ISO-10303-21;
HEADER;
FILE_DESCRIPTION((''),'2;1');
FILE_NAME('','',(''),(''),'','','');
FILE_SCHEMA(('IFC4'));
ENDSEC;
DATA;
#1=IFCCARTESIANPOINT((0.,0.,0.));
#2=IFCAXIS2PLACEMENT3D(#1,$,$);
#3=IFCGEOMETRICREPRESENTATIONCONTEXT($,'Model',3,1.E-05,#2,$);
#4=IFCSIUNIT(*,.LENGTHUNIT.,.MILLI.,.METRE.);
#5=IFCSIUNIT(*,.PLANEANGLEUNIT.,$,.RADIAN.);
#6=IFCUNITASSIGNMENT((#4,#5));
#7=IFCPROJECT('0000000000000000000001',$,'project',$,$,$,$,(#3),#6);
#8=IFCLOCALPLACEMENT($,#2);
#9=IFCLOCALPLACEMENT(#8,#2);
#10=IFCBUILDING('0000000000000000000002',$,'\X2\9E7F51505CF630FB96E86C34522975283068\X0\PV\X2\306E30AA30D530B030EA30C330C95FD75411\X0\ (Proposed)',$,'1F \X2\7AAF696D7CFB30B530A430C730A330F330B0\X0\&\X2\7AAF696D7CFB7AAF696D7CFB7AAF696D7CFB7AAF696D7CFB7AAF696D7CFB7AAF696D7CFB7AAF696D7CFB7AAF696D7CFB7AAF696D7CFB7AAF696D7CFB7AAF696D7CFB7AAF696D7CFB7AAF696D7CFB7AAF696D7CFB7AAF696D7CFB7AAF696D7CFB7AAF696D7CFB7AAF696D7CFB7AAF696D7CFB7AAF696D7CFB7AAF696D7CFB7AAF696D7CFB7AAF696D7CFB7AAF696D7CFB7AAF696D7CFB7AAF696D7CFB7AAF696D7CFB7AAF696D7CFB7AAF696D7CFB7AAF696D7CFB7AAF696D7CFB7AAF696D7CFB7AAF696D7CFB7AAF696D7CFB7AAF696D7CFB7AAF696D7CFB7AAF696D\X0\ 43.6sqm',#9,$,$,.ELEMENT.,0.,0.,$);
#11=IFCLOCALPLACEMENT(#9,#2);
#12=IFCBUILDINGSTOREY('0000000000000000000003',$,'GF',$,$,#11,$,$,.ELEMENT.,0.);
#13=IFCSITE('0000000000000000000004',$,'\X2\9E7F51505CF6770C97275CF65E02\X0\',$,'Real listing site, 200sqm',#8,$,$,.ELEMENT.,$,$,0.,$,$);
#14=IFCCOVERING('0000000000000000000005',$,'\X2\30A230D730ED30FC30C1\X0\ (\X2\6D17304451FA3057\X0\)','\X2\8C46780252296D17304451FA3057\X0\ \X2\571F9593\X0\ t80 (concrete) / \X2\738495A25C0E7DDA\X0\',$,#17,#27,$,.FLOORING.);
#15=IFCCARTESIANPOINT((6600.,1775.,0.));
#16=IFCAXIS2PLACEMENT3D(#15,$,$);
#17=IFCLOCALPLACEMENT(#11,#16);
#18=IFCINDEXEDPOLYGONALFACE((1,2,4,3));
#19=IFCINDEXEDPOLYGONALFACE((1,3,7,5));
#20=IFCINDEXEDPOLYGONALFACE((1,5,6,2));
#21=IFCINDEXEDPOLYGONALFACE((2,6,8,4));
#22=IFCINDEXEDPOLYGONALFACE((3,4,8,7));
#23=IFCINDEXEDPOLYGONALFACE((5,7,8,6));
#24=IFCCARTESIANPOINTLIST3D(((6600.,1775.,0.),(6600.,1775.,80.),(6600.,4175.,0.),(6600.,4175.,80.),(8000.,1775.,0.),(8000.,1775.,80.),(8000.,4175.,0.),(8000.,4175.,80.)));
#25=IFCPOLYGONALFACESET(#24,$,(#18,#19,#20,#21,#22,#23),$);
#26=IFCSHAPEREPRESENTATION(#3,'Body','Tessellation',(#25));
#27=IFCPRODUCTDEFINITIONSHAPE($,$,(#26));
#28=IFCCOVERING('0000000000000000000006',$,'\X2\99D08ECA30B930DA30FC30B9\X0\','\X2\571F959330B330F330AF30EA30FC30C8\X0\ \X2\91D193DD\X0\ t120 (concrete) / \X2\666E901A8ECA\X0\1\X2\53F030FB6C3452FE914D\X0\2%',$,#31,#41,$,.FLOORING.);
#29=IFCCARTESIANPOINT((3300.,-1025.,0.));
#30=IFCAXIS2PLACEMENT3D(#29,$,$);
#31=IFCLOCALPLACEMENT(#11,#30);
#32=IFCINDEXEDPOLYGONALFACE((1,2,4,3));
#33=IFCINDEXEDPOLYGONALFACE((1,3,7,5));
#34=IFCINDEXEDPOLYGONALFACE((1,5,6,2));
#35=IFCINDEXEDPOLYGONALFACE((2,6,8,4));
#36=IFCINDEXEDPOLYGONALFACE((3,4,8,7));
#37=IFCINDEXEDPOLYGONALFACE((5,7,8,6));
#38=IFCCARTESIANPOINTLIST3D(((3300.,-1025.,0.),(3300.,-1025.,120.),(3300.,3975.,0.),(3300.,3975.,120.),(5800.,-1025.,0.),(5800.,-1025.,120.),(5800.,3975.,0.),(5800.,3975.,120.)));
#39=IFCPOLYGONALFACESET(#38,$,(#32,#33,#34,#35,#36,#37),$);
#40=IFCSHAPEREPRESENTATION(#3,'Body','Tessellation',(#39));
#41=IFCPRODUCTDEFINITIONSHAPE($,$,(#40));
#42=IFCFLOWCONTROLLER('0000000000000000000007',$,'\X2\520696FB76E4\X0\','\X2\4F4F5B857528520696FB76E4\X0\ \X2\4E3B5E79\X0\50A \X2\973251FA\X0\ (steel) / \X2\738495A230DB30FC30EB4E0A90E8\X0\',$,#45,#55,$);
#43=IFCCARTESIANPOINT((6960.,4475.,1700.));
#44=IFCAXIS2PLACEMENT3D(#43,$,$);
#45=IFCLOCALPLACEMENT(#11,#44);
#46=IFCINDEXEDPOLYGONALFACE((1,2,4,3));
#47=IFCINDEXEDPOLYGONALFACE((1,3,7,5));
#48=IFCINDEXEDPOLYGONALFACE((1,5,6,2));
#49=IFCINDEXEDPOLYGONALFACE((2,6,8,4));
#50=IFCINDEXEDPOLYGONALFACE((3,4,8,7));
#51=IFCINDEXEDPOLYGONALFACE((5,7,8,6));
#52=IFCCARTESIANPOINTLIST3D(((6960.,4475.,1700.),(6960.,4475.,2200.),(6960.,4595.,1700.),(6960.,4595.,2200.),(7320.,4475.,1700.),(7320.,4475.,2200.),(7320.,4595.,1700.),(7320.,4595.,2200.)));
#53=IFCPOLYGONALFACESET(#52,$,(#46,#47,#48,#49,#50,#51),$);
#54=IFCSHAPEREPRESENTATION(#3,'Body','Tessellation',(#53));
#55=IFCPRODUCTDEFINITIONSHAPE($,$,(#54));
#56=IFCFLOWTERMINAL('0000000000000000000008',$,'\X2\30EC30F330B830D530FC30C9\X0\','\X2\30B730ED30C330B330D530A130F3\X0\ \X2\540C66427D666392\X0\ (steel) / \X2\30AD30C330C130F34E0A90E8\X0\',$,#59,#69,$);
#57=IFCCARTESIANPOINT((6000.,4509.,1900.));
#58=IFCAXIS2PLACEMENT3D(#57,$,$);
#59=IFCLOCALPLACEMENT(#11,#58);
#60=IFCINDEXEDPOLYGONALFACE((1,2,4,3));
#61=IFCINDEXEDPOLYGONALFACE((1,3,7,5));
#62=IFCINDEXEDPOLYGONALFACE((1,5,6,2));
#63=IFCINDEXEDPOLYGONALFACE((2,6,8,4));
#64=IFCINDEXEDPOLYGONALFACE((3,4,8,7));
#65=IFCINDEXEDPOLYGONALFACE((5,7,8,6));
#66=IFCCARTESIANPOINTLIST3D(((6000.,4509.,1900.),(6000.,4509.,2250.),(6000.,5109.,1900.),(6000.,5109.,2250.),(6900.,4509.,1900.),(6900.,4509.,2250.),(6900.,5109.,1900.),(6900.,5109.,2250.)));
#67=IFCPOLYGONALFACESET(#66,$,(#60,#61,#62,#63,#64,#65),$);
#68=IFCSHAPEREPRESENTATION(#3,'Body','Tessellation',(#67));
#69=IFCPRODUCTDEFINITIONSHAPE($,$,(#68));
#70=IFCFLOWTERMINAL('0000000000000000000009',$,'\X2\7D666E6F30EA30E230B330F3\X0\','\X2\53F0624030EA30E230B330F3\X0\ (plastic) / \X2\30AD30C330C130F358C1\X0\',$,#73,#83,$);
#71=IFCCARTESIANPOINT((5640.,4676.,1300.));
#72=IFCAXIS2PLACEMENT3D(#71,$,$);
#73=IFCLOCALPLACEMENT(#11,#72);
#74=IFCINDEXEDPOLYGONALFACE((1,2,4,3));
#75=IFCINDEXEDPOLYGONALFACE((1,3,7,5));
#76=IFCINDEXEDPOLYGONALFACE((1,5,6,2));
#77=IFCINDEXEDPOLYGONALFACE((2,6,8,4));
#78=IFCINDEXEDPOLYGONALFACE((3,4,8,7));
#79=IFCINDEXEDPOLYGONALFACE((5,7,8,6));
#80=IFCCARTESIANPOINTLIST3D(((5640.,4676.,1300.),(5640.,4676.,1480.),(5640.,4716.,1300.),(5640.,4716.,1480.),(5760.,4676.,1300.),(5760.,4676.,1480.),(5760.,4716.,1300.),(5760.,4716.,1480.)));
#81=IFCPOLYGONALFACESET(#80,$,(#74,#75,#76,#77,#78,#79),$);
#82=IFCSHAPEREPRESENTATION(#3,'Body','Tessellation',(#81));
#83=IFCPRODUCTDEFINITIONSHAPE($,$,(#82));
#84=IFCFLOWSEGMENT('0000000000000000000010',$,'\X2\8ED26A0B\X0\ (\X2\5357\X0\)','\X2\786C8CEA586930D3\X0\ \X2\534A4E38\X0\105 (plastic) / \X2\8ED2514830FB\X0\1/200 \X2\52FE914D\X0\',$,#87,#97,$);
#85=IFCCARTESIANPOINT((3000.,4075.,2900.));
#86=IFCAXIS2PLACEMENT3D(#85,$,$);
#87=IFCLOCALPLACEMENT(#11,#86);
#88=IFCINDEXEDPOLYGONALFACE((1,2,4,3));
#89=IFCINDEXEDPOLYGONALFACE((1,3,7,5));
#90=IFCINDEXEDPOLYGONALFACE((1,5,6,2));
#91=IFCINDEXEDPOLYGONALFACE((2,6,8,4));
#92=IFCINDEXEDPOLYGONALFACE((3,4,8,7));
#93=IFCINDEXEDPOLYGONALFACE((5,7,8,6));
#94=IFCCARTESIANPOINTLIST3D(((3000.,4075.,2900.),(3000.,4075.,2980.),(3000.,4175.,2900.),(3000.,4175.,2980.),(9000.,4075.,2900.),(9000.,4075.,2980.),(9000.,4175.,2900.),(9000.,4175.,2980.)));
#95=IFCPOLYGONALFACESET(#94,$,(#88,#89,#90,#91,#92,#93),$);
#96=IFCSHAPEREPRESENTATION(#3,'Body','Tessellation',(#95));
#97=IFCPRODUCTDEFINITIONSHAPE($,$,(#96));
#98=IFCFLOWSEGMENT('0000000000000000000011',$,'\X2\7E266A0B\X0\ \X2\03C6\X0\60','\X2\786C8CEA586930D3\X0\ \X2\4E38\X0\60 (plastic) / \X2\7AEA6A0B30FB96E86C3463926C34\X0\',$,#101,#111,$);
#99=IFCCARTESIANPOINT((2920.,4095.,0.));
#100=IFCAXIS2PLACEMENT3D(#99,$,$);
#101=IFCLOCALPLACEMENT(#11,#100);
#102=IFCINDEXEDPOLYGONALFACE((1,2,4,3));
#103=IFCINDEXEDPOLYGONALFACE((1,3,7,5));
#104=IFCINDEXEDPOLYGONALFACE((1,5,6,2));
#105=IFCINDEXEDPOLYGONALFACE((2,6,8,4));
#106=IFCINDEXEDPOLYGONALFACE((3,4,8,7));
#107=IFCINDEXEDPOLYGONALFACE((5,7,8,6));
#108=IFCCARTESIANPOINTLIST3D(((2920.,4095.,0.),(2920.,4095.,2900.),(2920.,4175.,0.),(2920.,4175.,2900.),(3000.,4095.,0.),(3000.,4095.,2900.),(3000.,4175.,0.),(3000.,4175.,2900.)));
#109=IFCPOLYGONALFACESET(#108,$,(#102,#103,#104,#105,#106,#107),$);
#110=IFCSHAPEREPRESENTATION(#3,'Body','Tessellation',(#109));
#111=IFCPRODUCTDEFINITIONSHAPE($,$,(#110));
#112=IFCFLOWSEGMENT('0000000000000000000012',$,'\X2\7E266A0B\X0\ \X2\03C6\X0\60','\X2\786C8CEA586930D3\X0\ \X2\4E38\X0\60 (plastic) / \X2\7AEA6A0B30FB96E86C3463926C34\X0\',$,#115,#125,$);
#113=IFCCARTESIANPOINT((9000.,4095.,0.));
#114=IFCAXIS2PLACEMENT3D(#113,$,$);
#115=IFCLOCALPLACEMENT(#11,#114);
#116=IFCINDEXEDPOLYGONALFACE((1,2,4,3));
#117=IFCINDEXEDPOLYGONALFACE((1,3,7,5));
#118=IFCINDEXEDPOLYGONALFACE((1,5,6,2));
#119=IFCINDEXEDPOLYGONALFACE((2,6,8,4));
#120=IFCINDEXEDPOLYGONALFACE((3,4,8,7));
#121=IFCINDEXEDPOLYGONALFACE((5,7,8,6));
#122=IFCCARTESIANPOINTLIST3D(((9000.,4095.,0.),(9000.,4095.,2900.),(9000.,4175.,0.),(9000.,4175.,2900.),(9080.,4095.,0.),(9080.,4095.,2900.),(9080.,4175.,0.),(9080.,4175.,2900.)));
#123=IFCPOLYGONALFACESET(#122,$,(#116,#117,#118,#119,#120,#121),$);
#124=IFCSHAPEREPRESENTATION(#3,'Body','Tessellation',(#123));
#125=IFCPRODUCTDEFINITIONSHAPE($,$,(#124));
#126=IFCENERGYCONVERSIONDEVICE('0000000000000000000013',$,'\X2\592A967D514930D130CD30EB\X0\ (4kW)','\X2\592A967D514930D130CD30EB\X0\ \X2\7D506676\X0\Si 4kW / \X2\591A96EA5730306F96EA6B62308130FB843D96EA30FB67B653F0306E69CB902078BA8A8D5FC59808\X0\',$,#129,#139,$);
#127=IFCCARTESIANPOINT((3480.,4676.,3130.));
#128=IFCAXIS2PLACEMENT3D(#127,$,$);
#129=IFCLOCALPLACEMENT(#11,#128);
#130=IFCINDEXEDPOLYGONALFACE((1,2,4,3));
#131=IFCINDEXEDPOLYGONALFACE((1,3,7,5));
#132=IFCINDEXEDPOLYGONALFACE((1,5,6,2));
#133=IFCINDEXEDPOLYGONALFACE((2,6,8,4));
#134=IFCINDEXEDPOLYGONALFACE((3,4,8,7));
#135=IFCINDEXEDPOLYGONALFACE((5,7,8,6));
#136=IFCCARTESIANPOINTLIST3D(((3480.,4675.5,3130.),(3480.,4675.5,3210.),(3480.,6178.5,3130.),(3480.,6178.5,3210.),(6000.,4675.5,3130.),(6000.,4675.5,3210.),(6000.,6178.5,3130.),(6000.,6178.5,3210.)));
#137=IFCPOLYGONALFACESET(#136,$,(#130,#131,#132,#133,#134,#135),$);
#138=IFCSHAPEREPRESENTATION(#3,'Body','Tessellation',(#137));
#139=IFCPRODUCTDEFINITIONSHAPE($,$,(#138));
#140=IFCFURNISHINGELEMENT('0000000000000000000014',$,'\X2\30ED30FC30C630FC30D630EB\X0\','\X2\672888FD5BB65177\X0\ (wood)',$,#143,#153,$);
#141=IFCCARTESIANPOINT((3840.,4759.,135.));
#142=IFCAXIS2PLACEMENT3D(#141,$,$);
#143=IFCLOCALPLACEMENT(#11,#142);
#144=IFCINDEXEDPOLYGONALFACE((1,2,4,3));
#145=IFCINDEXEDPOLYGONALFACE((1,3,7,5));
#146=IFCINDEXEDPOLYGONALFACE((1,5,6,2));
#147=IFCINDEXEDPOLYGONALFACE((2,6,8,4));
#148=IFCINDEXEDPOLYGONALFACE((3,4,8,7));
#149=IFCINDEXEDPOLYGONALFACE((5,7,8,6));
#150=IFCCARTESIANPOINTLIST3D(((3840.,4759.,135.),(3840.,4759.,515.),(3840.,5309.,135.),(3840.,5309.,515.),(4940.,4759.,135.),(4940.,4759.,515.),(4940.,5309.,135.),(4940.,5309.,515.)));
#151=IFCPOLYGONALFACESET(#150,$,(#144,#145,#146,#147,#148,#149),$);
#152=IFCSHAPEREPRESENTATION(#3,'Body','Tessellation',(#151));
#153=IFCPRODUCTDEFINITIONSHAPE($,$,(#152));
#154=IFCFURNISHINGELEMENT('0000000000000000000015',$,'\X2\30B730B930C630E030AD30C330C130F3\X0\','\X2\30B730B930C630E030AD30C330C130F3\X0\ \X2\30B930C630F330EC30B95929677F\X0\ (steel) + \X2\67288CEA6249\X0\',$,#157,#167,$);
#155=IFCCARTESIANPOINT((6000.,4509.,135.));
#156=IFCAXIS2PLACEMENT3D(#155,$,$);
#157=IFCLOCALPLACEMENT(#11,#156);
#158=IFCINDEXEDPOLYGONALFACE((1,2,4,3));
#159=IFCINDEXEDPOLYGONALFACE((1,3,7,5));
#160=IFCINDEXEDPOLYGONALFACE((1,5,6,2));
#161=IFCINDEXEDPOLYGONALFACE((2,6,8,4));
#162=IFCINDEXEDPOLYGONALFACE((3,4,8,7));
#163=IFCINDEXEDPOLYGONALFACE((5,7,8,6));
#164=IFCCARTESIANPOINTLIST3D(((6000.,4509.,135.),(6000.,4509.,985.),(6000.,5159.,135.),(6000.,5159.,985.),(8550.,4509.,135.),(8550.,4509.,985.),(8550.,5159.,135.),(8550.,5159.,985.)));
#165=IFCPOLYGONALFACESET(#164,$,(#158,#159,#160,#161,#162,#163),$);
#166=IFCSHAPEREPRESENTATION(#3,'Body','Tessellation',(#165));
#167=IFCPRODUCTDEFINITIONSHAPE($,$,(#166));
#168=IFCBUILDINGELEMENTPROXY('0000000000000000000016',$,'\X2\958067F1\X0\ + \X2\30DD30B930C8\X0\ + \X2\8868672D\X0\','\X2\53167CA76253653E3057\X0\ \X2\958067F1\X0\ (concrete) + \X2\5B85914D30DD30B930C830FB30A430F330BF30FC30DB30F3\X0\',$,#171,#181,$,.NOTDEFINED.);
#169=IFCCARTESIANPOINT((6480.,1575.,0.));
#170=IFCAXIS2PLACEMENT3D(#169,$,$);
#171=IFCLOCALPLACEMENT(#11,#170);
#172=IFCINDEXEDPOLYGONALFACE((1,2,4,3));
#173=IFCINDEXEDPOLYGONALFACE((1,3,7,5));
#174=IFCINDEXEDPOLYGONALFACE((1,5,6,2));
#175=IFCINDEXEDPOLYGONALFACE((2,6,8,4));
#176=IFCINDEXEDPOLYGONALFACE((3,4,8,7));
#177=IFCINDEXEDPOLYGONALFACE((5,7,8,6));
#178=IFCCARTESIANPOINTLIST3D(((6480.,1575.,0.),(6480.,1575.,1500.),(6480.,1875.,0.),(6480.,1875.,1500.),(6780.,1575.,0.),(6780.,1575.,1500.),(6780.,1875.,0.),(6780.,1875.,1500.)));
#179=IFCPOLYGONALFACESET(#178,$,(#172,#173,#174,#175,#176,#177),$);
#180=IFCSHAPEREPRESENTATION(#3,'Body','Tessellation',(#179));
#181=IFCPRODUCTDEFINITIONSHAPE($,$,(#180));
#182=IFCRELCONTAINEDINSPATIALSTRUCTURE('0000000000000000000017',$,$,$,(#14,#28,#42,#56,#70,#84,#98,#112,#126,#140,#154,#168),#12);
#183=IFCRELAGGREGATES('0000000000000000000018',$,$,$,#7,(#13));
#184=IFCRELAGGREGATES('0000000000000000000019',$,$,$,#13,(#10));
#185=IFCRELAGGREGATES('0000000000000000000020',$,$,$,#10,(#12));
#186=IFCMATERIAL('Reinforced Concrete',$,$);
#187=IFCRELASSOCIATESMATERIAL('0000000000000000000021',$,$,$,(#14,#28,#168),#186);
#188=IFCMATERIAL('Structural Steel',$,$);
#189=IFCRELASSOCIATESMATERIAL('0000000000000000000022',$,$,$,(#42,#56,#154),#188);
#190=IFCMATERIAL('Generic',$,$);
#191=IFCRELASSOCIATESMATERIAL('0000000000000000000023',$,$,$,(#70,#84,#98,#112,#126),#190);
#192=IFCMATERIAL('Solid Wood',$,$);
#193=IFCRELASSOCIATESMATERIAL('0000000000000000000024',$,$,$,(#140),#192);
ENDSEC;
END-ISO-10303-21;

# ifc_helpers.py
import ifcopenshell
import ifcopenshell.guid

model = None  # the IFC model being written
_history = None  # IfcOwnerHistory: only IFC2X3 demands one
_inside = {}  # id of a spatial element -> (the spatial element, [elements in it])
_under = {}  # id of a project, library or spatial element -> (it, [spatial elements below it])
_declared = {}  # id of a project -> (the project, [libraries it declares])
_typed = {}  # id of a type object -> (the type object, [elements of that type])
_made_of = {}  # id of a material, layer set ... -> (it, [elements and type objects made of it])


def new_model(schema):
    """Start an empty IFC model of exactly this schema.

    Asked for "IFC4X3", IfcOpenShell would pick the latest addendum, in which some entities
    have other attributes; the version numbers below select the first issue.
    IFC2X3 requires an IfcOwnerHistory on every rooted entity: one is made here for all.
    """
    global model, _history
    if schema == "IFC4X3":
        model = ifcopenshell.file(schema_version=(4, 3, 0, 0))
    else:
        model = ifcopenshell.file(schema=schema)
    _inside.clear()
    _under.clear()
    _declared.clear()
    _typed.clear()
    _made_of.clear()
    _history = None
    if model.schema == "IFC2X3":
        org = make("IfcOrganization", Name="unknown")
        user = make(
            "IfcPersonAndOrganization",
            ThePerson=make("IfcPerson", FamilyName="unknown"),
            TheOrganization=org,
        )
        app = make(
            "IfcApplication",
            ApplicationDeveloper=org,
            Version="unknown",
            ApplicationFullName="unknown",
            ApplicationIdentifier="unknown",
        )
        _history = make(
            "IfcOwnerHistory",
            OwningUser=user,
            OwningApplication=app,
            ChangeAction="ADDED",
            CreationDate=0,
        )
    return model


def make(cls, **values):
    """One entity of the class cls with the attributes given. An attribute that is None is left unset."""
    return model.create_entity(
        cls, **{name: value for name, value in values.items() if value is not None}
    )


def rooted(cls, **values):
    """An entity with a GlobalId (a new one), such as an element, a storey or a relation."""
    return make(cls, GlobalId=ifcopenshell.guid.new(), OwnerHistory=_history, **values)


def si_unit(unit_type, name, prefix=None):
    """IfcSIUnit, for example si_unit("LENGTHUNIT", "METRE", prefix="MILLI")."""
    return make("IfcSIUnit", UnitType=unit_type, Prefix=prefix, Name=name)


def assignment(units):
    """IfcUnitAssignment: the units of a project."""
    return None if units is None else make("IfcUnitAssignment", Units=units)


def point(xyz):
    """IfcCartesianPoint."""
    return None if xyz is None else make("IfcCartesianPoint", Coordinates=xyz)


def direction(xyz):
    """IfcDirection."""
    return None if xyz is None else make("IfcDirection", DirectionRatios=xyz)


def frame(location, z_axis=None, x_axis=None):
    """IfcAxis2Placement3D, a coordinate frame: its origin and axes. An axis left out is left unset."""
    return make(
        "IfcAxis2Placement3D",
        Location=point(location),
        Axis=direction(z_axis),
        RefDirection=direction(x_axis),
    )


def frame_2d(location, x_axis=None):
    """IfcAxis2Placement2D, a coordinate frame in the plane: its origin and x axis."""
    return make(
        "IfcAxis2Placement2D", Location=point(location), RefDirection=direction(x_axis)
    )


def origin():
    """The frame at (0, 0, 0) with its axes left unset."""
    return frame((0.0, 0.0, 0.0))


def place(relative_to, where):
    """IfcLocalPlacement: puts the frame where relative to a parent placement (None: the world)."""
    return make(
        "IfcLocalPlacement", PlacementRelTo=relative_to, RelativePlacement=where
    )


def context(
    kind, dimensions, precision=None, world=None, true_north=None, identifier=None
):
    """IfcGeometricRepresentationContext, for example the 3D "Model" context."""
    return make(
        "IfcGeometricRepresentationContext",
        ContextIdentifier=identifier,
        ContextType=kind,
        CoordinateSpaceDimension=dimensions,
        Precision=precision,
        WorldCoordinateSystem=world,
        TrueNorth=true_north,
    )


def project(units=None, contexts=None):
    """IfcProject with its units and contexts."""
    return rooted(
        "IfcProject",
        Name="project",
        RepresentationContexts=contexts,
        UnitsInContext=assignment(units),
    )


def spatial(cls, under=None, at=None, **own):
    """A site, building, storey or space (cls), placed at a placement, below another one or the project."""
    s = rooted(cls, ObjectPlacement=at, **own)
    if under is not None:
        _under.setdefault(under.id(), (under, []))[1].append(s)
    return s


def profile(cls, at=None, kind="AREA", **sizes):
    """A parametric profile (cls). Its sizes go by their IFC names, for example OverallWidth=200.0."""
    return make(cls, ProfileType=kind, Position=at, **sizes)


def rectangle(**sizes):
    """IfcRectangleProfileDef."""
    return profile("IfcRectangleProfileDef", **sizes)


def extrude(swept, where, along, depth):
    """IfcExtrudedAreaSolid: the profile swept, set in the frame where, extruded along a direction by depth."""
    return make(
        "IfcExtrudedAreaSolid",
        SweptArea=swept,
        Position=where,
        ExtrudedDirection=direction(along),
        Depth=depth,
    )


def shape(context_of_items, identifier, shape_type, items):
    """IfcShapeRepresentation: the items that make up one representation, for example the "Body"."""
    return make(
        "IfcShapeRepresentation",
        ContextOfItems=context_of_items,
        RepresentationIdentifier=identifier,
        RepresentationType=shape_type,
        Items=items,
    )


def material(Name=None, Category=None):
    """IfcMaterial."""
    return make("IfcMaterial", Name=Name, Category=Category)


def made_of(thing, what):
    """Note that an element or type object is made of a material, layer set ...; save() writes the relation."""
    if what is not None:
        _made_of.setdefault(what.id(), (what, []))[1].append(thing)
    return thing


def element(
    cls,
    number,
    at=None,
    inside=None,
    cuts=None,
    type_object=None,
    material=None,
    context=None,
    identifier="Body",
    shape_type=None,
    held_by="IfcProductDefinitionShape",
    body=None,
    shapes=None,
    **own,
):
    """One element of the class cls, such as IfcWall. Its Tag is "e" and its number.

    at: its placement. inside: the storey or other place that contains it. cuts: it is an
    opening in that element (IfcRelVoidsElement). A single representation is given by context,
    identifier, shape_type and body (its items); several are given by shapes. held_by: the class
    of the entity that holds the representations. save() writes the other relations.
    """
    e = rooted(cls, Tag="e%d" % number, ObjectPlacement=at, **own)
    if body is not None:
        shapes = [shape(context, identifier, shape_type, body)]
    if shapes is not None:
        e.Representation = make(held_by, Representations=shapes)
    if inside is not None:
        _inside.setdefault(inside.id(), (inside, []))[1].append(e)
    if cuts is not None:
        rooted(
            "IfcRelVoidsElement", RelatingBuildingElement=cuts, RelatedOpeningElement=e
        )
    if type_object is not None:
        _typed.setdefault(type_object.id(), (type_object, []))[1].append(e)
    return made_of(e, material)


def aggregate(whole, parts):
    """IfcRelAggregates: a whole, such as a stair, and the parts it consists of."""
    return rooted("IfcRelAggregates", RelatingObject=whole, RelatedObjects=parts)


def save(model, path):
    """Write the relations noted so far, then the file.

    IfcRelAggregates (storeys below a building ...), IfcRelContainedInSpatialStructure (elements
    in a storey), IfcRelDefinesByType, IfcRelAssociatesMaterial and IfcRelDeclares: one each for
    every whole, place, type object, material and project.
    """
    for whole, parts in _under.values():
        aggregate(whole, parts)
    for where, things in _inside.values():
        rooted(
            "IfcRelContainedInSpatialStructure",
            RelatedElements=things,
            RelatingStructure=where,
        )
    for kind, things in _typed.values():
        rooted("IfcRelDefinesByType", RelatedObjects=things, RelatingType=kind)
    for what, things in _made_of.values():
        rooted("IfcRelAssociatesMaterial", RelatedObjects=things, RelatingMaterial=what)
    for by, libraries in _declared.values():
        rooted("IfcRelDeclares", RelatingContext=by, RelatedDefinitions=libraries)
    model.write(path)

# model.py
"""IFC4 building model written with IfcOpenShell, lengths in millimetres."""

from ifc_helpers import new_model, si_unit, frame, frame_2d, origin, place, context, project, spatial, rectangle, extrude, material, element, save


model = new_model("IFC4")

# Units and contexts
model_context = context("Model", 3, precision=1e-05, world=origin())
ifc_project = project(units=[si_unit("LENGTHUNIT", "METRE", prefix="MILLI"), si_unit("PLANEANGLEUNIT", "RADIAN")], contexts=[model_context])

# Site, building, storey
site_placement = place(None, origin())
site = spatial("IfcSite", under=ifc_project, at=site_placement, Name="鹿児島県霧島市", ObjectType="Real listing site, 200sqm", CompositionType="ELEMENT", RefElevation=0.0)
building_placement = place(site_placement, origin())
building = spatial("IfcBuilding", under=site, at=building_placement, Name="鹿児島・雨水利用とPVのオフグリッド志向 (Proposed)", ObjectType="1F 窯業系サイディング&窯業系窯業系窯業系窯業系窯業系窯業系窯業系窯業系窯業系窯業系窯業系窯業系窯業系窯業系窯業系窯業系窯業系窯業系窯業系窯業系窯業系窯業系窯業系窯業系窯業系窯業系窯業系窯業系窯業系窯業系窯業系窯業系窯業系窯業系窯業系窯業系窯業 43.6sqm", CompositionType="ELEMENT", ElevationOfRefHeight=0.0, ElevationOfTerrain=0.0)
storey_placement = place(building_placement, origin())
storey = spatial("IfcBuildingStorey", under=building, at=storey_placement, Name="GF", CompositionType="ELEMENT", Elevation=0.0)

# Shared definitions
ifc_material_1 = material(Name="Solid Wood")

# Shared definitions
ifc_material_2 = material(Name="Reinforced Concrete")

# Shared definitions
ifc_material_3 = material(Name="Structural Steel")

# Coverings
ifc_material_4 = material(Name="Generic")
covering_1_placement = place(storey_placement, frame((6600.0, 1775.0, 0.0)))
element("IfcCovering", 1, at=covering_1_placement, inside=storey, material=ifc_material_2, Name="アプローチ (洗い出し)", Description="豆砂利洗い出し 土間 t80 (concrete) / 玄関導線", PredefinedType="FLOORING", context=model_context, shape_type="SweptSolid", body=[
    extrude(rectangle(XDim=1400.0, YDim=2400.0, at=frame_2d((700.0, 1200.0))), frame((6600.0, 1775.0, 0.0)), (0.0, 0.0, 1.0), 80.0),
])
covering_2_placement = place(storey_placement, frame((3300.0, -1025.0, 0.0)))
element("IfcCovering", 2, at=covering_2_placement, inside=storey, material=ifc_material_2, Name="駐車スペース", Description="土間コンクリート 金鏝 t120 (concrete) / 普通車1台・水勾配2%", PredefinedType="FLOORING", context=model_context, shape_type="SweptSolid", body=[
    extrude(rectangle(XDim=2500.0, YDim=5000.0, at=frame_2d((1250.0, 2500.0))), frame((3300.0, -1025.0, 0.0)), (0.0, 0.0, 1.0), 120.0),
])

# Flow controller
flow_controller_placement = place(storey_placement, frame((6960.0, 4475.0, 1700.0)))
element("IfcFlowController", 3, at=flow_controller_placement, inside=storey, material=ifc_material_3, Name="分電盤", Description="住宅用分電盤 主幹50A 露出 (steel) / 玄関ホール上部", context=model_context, shape_type="SweptSolid", body=[
    extrude(rectangle(XDim=360.0, YDim=120.0, at=frame_2d((180.0, 60.0))), frame((6960.0, 4475.0, 1700.0)), (0.0, 0.0, 1.0), 500.0),
])

# Flow terminals
flow_terminal_1_placement = place(storey_placement, frame((6000.0, 4509.0, 1900.0)))
element("IfcFlowTerminal", 4, at=flow_terminal_1_placement, inside=storey, material=ifc_material_3, Name="レンジフード", Description="シロッコファン 同時給排 (steel) / キッチン上部", context=model_context, shape_type="SweptSolid", body=[
    extrude(rectangle(XDim=900.0, YDim=600.0, at=frame_2d((450.0, 300.0))), frame((6000.0, 4509.0, 1900.0)), (0.0, 0.0, 1.0), 350.0),
])
flow_terminal_2_placement = place(storey_placement, frame((5640.0, 4676.0, 1300.0)))
element("IfcFlowTerminal", 5, at=flow_terminal_2_placement, inside=storey, material=ifc_material_4, Name="給湯リモコン", Description="台所リモコン (plastic) / キッチン壁", context=model_context, shape_type="SweptSolid", body=[
    extrude(rectangle(XDim=120.0, YDim=40.0, at=frame_2d((60.0, 20.0))), frame((5640.0, 4676.0, 1300.0)), (0.0, 0.0, 1.0), 180.0),
])

# Flow segments
flow_segment_1_placement = place(storey_placement, frame((3000.0, 4075.0, 2900.0)))
element("IfcFlowSegment", 6, at=flow_segment_1_placement, inside=storey, material=ifc_material_4, Name="軒樋 (南)", Description="硬質塩ビ 半丸105 (plastic) / 軒先・1/200 勾配", context=model_context, shape_type="SweptSolid", body=[
    extrude(rectangle(XDim=6000.0, YDim=100.0, at=frame_2d((3000.0, 50.0))), frame((3000.0, 4075.0, 2900.0)), (0.0, 0.0, 1.0), 80.0),
])
flow_segment_2_placement = place(storey_placement, frame((2920.0, 4095.0, 0.0)))
element("IfcFlowSegment", 7, at=flow_segment_2_placement, inside=storey, material=ifc_material_4, Name="縦樋 φ60", Description="硬質塩ビ 丸60 (plastic) / 竪樋・雨水排水", context=model_context, shape_type="SweptSolid", body=[
    extrude(rectangle(XDim=80.0, YDim=80.0, at=frame_2d((40.0, 40.0))), frame((2920.0, 4095.0, 0.0)), (0.0, 0.0, 1.0), 2900.0),
])
flow_segment_3_placement = place(storey_placement, frame((9000.0, 4095.0, 0.0)))
element("IfcFlowSegment", 8, at=flow_segment_3_placement, inside=storey, material=ifc_material_4, Name="縦樋 φ60", Description="硬質塩ビ 丸60 (plastic) / 竪樋・雨水排水", context=model_context, shape_type="SweptSolid", body=[
    extrude(rectangle(XDim=80.0, YDim=80.0, at=frame_2d((40.0, 40.0))), frame((9000.0, 4095.0, 0.0)), (0.0, 0.0, 1.0), 2900.0),
])

# Energy conversion device
energy_conversion_device_placement = place(storey_placement, frame((3480.0, 4676.0, 3130.0)))
element("IfcEnergyConversionDevice", 9, at=energy_conversion_device_placement, inside=storey, material=ifc_material_4, Name="太陽光パネル (4kW)", Description="太陽光パネル 結晶Si 4kW / 多雪地は雪止め・落雪・架台の構造確認必須", context=model_context, shape_type="SweptSolid", body=[
    extrude(rectangle(XDim=2520.0, YDim=1503.0, at=frame_2d((1260.0, 751.0))), frame((3480.0, 4676.0, 3130.0)), (0.0, 0.0, 1.0), 80.0),
])

# Furnishing elements
furnishing_1_placement = place(storey_placement, frame((3840.0, 4759.0, 135.0)))
element("IfcFurnishingElement", 10, at=furnishing_1_placement, inside=storey, material=ifc_material_1, Name="ローテーブル", Description="木製家具 (wood)", context=model_context, shape_type="SweptSolid", body=[
    extrude(rectangle(XDim=1100.0, YDim=550.0, at=frame_2d((550.0, 275.0))), frame((3840.0, 4759.0, 135.0)), (0.0, 0.0, 1.0), 380.0),
])
furnishing_2_placement = place(storey_placement, frame((6000.0, 4509.0, 135.0)))
element("IfcFurnishingElement", 11, at=furnishing_2_placement, inside=storey, material=ifc_material_3, Name="システムキッチン", Description="システムキッチン ステンレス天板 (steel) + 木質扉", context=model_context, shape_type="SweptSolid", body=[
    extrude(rectangle(XDim=2550.0, YDim=650.0, at=frame_2d((1275.0, 325.0))), frame((6000.0, 4509.0, 135.0)), (0.0, 0.0, 1.0), 850.0),
])

# Building element proxy
proxy_placement = place(storey_placement, frame((6480.0, 1575.0, 0.0)))
element("IfcBuildingElementProxy", 12, at=proxy_placement, inside=storey, material=ifc_material_2, Name="門柱 + ポスト + 表札", Description="化粧打放し 門柱 (concrete) + 宅配ポスト・インターホン", PredefinedType="NOTDEFINED", context=model_context, shape_type="SweptSolid", body=[
    extrude(rectangle(XDim=300.0, YDim=300.0, at=frame_2d((150.0, 150.0))), frame((6480.0, 1575.0, 0.0)), (0.0, 0.0, 1.0), 1500.0),
])

save(model, "model.ifc")
